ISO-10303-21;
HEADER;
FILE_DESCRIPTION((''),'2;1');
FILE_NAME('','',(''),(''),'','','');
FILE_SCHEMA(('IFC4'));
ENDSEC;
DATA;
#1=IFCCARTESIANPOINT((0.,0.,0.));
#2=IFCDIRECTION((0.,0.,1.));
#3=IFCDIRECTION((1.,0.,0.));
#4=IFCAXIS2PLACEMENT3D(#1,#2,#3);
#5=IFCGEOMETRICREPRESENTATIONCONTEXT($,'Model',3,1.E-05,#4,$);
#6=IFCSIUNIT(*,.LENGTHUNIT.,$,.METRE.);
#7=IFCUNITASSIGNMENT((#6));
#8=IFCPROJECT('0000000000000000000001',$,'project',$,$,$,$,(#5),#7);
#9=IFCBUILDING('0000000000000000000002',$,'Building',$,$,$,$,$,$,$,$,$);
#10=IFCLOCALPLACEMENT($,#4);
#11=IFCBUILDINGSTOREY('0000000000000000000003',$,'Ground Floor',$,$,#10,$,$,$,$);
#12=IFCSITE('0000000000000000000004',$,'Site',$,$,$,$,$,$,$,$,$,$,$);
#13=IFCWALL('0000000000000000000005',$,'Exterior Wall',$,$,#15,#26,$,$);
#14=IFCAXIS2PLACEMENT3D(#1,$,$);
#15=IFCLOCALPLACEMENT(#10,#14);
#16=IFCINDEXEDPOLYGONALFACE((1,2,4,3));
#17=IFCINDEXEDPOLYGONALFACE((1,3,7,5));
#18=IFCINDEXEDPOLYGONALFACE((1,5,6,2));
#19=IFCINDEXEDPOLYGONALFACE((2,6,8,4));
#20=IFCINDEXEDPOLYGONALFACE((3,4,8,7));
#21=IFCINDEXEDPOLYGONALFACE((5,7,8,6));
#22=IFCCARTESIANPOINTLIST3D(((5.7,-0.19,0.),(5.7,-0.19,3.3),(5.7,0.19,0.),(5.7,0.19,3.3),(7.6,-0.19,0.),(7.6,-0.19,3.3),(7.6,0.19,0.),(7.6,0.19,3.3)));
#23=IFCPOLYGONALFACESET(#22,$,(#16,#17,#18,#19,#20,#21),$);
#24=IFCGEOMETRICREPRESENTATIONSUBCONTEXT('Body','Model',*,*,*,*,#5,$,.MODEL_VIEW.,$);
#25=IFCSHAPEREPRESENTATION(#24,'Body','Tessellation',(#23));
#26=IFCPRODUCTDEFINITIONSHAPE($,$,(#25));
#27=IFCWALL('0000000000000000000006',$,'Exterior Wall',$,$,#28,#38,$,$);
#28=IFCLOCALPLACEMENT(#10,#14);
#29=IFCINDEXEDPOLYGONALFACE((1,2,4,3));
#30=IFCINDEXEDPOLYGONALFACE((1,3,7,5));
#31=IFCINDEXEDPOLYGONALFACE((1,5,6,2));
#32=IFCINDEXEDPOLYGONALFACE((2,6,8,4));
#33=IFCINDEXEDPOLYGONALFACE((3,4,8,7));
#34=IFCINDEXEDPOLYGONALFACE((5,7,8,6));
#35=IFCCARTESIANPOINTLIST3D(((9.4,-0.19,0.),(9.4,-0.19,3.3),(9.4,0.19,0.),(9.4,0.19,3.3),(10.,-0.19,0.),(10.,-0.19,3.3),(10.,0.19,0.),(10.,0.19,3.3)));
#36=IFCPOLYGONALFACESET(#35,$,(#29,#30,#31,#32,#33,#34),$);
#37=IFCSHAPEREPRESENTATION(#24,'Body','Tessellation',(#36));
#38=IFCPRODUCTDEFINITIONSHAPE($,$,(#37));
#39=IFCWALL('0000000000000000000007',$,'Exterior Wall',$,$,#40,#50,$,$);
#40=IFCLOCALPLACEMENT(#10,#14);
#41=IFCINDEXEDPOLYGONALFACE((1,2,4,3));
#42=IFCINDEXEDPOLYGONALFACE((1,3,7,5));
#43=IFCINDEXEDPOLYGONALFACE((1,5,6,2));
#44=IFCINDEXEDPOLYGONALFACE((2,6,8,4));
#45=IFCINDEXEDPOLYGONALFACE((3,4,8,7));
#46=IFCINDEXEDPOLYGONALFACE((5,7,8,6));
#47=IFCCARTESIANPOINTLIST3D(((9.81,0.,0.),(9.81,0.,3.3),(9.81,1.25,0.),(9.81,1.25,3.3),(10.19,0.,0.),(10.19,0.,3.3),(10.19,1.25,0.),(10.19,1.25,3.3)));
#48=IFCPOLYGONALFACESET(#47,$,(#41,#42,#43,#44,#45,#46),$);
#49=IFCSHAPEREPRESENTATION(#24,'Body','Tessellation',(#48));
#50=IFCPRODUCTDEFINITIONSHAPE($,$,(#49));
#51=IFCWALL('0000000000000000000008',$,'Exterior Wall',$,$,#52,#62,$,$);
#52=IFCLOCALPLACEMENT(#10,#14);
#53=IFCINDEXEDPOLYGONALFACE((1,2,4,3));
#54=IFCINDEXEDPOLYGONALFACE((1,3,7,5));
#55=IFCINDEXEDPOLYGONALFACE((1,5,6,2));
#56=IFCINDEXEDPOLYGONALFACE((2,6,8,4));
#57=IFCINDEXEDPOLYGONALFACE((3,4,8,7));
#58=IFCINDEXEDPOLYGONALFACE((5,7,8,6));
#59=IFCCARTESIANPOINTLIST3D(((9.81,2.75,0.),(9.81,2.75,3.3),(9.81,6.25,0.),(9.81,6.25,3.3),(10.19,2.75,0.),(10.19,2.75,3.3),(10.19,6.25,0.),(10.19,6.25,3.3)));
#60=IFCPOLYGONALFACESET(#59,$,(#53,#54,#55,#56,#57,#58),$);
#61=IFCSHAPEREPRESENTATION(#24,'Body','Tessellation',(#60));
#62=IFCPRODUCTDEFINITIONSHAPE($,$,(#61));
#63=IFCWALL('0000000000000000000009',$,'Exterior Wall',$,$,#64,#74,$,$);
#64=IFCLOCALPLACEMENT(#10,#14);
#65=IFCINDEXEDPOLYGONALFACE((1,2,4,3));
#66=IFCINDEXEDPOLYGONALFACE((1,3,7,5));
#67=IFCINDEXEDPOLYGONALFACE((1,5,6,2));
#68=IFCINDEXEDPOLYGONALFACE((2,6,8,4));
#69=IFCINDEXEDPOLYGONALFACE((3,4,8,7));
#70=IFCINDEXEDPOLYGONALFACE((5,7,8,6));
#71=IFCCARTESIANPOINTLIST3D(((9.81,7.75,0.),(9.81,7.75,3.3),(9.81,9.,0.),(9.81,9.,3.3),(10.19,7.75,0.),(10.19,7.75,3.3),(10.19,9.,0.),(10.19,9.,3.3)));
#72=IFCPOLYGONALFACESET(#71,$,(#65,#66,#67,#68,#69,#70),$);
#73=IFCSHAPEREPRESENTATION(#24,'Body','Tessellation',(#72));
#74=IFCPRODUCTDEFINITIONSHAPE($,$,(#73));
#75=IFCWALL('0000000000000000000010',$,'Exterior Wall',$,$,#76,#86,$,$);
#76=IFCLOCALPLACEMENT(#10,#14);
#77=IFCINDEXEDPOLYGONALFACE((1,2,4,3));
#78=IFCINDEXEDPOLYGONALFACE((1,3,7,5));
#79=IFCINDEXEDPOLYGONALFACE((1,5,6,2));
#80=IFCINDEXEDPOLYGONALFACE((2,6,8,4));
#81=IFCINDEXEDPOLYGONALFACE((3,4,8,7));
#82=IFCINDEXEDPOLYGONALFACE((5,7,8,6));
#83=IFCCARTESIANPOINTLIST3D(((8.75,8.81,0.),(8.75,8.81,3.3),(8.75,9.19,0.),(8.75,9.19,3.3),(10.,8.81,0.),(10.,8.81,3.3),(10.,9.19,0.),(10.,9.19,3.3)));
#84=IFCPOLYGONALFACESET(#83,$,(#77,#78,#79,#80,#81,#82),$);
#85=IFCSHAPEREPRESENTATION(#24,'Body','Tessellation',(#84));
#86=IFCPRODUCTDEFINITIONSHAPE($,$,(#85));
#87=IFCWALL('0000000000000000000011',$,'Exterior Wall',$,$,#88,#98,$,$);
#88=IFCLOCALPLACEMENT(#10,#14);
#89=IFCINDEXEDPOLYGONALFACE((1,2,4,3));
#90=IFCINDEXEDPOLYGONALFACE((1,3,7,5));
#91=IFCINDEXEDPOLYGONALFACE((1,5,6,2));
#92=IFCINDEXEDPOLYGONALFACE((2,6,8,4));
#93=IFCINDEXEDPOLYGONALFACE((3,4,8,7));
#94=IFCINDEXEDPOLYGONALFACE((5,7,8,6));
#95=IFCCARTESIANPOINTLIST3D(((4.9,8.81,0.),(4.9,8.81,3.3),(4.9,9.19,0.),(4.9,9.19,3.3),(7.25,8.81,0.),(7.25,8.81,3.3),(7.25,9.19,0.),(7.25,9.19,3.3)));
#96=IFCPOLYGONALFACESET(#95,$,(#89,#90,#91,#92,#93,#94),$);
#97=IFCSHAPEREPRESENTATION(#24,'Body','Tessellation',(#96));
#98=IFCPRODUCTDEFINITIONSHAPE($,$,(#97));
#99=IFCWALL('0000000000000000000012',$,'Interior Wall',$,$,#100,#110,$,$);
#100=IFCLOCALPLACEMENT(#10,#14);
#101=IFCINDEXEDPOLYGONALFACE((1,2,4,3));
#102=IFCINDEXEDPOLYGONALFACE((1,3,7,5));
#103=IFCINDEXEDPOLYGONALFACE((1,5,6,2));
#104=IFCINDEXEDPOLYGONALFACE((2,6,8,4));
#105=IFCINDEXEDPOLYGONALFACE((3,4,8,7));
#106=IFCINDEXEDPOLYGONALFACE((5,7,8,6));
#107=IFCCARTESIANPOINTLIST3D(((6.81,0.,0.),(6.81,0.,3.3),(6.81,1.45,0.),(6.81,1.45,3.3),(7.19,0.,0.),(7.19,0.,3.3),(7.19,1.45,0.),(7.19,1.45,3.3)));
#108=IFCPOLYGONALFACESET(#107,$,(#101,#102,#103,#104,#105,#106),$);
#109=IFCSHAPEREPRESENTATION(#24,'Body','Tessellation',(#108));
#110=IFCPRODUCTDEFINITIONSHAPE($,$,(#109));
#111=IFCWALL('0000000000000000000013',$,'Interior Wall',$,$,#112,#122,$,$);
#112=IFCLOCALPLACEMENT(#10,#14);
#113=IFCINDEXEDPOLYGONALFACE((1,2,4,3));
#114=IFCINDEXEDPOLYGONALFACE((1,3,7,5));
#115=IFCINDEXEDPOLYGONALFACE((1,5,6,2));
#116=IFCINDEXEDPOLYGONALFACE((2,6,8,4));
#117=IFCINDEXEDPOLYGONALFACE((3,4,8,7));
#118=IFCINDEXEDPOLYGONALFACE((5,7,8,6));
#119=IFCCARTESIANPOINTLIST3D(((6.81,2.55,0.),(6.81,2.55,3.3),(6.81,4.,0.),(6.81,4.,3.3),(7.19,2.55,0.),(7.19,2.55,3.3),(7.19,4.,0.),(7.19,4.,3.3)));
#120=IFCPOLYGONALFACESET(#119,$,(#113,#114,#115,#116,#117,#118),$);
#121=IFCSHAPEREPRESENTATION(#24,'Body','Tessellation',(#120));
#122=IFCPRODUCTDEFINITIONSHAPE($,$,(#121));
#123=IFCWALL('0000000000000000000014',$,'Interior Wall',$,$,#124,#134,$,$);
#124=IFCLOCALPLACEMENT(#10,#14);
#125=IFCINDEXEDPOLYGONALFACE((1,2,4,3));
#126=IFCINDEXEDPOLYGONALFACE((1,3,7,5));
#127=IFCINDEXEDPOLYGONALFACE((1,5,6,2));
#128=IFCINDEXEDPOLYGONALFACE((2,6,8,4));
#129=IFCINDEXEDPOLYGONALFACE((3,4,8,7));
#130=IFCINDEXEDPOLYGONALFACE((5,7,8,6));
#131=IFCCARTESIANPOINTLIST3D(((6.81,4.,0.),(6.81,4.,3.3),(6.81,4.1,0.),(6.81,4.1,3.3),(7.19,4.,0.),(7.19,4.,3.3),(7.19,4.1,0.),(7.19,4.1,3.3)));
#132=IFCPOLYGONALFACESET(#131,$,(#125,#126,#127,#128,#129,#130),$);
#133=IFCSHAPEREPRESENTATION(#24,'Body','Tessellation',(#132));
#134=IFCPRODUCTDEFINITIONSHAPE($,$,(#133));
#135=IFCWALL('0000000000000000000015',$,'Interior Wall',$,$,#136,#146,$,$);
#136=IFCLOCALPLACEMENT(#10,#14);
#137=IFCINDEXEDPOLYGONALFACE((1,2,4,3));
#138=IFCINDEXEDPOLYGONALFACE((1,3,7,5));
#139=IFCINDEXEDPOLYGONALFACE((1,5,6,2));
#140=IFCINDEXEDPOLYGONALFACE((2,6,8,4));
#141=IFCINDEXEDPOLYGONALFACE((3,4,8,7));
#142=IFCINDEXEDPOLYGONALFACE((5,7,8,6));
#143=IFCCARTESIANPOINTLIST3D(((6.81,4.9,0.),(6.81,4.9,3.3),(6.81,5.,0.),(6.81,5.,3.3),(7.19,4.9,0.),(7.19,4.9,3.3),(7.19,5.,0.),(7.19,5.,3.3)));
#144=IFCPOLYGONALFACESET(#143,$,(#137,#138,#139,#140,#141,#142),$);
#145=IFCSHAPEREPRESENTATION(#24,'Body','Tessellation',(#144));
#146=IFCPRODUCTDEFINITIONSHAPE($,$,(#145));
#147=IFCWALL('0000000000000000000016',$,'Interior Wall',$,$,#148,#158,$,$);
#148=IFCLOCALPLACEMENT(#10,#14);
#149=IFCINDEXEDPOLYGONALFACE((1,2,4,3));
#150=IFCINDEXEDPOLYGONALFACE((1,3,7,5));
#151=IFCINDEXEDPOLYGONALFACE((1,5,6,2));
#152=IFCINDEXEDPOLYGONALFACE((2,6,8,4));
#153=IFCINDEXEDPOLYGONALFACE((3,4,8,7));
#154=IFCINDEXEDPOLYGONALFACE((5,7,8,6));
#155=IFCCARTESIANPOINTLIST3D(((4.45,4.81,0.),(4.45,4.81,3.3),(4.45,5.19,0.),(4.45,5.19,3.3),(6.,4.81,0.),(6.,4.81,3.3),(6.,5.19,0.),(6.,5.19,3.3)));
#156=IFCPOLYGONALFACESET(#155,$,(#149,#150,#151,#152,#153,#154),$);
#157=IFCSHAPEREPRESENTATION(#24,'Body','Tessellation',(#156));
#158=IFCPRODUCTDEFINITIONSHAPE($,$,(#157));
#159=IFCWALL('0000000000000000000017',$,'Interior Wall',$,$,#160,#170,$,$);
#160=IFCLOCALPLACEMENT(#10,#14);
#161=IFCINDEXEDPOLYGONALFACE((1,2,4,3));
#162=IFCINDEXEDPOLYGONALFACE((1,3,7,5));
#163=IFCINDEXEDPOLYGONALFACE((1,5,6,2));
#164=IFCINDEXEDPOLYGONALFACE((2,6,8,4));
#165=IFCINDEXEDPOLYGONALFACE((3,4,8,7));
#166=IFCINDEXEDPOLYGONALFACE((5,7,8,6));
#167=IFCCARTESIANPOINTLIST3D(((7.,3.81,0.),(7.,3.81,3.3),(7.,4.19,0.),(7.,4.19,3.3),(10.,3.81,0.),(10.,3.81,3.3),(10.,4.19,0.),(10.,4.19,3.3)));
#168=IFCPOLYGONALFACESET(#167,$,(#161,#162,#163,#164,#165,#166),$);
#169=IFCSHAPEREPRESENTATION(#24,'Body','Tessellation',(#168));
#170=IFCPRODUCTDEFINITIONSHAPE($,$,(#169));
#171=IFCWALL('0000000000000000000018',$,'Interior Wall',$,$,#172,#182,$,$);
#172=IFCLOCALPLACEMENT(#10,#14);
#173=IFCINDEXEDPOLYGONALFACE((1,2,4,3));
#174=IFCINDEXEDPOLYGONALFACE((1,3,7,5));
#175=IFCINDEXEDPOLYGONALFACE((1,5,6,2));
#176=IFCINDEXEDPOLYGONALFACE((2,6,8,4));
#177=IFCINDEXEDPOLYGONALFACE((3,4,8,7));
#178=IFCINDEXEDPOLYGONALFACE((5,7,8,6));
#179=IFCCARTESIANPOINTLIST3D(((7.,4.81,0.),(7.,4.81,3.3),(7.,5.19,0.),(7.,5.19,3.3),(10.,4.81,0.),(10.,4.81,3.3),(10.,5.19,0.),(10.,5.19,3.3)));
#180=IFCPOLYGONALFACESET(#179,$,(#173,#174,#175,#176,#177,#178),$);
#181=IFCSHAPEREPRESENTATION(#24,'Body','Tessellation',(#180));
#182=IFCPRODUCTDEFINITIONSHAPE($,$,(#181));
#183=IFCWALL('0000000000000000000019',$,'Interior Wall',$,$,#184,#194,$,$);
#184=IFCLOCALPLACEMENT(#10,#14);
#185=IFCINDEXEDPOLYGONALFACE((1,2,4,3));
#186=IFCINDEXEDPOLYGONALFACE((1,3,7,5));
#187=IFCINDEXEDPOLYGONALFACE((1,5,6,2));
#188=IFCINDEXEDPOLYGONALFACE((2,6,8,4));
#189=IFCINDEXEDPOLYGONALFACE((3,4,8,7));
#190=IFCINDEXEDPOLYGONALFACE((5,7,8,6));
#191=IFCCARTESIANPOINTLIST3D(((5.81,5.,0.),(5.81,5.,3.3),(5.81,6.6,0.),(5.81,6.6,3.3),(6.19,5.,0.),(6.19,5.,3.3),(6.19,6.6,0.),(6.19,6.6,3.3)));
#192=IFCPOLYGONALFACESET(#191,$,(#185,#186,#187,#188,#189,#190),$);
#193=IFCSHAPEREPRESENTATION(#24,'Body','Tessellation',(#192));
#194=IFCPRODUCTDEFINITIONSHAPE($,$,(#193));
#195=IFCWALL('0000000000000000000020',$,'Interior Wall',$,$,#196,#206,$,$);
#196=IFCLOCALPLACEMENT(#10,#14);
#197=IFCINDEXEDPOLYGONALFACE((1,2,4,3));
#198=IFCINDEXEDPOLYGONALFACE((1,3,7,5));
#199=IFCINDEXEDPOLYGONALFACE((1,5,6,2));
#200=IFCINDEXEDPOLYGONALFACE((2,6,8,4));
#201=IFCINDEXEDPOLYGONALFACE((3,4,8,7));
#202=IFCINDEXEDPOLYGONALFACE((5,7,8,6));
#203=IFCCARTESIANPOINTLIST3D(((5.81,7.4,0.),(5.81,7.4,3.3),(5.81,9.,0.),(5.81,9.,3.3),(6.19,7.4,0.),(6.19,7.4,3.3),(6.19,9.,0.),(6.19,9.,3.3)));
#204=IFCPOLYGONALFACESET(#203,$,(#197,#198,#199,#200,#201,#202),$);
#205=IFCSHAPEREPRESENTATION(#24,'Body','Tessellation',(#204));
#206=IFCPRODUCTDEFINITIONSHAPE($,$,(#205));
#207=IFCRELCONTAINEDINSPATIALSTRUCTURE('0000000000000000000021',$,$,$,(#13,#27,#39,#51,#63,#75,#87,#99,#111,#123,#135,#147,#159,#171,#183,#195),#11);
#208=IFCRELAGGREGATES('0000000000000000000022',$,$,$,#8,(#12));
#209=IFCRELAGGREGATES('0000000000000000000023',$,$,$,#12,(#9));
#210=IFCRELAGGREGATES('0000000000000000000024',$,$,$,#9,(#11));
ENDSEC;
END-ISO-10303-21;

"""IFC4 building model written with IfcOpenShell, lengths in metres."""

from ifc_helpers import new_model, si_unit, frame, origin_with_axes, place, context, subcontext, project, spatial, indexed_curve, outline, extrude, element, save


model = new_model("IFC4")

# Units and contexts
model_context = context("Model", 3, precision=1e-05, world=origin_with_axes())
body_context = subcontext(model_context, "Body", "Model", "MODEL_VIEW")
ifc_project = project(units=[si_unit("LENGTHUNIT", "METRE")], contexts=[model_context])

# Site, building, storey
site = spatial("IfcSite", under=ifc_project, Name="Site")
building = spatial("IfcBuilding", under=site, Name="Building")
storey_placement = place(None, origin_with_axes())
storey = spatial("IfcBuildingStorey", under=building, at=storey_placement, Name="Ground Floor")

# Walls
wall_1_placement = place(storey_placement, frame((5.7, 0.0, 0.0), z_axis=(0.0, 0.0, 1.0), x_axis=(1.0, 0.0, 0.0)))
element("IfcWall", 1, at=wall_1_placement, inside=storey, Name="Exterior Wall", context=body_context, shape_type="SweptSolid", body=[
    extrude(outline(indexed_curve([(0.0, 0.0), (0.0, 0.38), (1.9, 0.38), (1.9, 0.0), (0.0, 0.0)], self_intersect=False)), frame((0.0, -0.19, 0.0), z_axis=(0.0, 0.0, 1.0), x_axis=(1.0, 0.0, 0.0)), (0.0, 0.0, 1.0), 3.3),
])
wall_2_placement = place(storey_placement, frame((9.4, 0.0, 0.0), z_axis=(0.0, 0.0, 1.0), x_axis=(1.0, 0.0, 0.0)))
element("IfcWall", 2, at=wall_2_placement, inside=storey, Name="Exterior Wall", context=body_context, shape_type="SweptSolid", body=[
    extrude(outline(indexed_curve([(0.0, 0.0), (0.0, 0.38), (0.6, 0.38), (0.6, 0.0), (0.0, 0.0)], self_intersect=False)), frame((0.0, -0.19, 0.0), z_axis=(0.0, 0.0, 1.0), x_axis=(1.0, 0.0, 0.0)), (0.0, 0.0, 1.0), 3.3),
])
wall_3_placement = place(storey_placement, frame((10.0, 0.0, 0.0), z_axis=(0.0, 0.0, 1.0), x_axis=(0.0, 1.0, 0.0)))
element("IfcWall", 3, at=wall_3_placement, inside=storey, Name="Exterior Wall", context=body_context, shape_type="SweptSolid", body=[
    extrude(outline(indexed_curve([(0.0, 0.0), (0.0, 0.38), (1.25, 0.38), (1.25, 0.0), (0.0, 0.0)], self_intersect=False)), frame((0.0, -0.19, 0.0), z_axis=(0.0, 0.0, 1.0), x_axis=(1.0, 0.0, 0.0)), (0.0, 0.0, 1.0), 3.3),
])
wall_4_placement = place(storey_placement, frame((10.0, 2.75, 0.0), z_axis=(0.0, 0.0, 1.0), x_axis=(0.0, 1.0, 0.0)))
element("IfcWall", 4, at=wall_4_placement, inside=storey, Name="Exterior Wall", context=body_context, shape_type="SweptSolid", body=[
    extrude(outline(indexed_curve([(0.0, 0.0), (0.0, 0.38), (3.5, 0.38), (3.5, 0.0), (0.0, 0.0)], self_intersect=False)), frame((0.0, -0.19, 0.0), z_axis=(0.0, 0.0, 1.0), x_axis=(1.0, 0.0, 0.0)), (0.0, 0.0, 1.0), 3.3),
])
for number, where, z_axis, x_axis, name in (
    (5, (10.0, 7.75, 0.0), (0.0, 0.0, 1.0), (0.0, 1.0, 0.0), "Exterior Wall"),
    (6, (10.0, 9.0, 0.0), (0.0, 0.0, 1.0), (-1.0, 0.0, 0.0), "Exterior Wall"),
):
    element("IfcWall", number, at=place(storey_placement, frame(where, z_axis=z_axis, x_axis=x_axis)), inside=storey, Name=name, context=body_context, shape_type="SweptSolid", body=[
        extrude(outline(indexed_curve([(0.0, 0.0), (0.0, 0.38), (1.25, 0.38), (1.25, 0.0), (0.0, 0.0)], self_intersect=False)), frame((0.0, -0.19, 0.0), z_axis=(0.0, 0.0, 1.0), x_axis=(1.0, 0.0, 0.0)), (0.0, 0.0, 1.0), 3.3),
    ])
wall_5_placement = place(storey_placement, frame((7.25, 9.0, 0.0), z_axis=(0.0, 0.0, 1.0), x_axis=(-1.0, 0.0, 0.0)))
element("IfcWall", 7, at=wall_5_placement, inside=storey, Name="Exterior Wall", context=body_context, shape_type="SweptSolid", body=[
    extrude(outline(indexed_curve([(0.0, 0.0), (0.0, 0.38), (2.35, 0.38), (2.35, 0.0), (0.0, 0.0)], self_intersect=False)), frame((0.0, -0.19, 0.0), z_axis=(0.0, 0.0, 1.0), x_axis=(1.0, 0.0, 0.0)), (0.0, 0.0, 1.0), 3.3),
])
wall_6_placement = place(storey_placement, frame((7.0, 0.0, 0.0), z_axis=(0.0, 0.0, 1.0), x_axis=(0.0, 1.0, 0.0)))
element("IfcWall", 8, at=wall_6_placement, inside=storey, Name="Interior Wall", context=body_context, shape_type="SweptSolid", body=[
    extrude(outline(indexed_curve([(0.0, 0.0), (0.0, 0.38), (1.45, 0.38), (1.45, 0.0), (0.0, 0.0)], self_intersect=False)), frame((0.0, -0.19, 0.0), z_axis=(0.0, 0.0, 1.0), x_axis=(1.0, 0.0, 0.0)), (0.0, 0.0, 1.0), 3.3),
])
wall_7_placement = place(storey_placement, frame((7.0, 2.55, 0.0), z_axis=(0.0, 0.0, 1.0), x_axis=(0.0, 1.0, 0.0)))
element("IfcWall", 9, at=wall_7_placement, inside=storey, Name="Interior Wall", context=body_context, shape_type="SweptSolid", body=[
    extrude(outline(indexed_curve([(0.0, 0.0), (0.0, 0.38), (1.45, 0.38), (1.45, 0.0), (0.0, 0.0)], self_intersect=False)), frame((0.0, -0.19, 0.0), z_axis=(0.0, 0.0, 1.0), x_axis=(1.0, 0.0, 0.0)), (0.0, 0.0, 1.0), 3.3),
])
for number, where, z_axis, x_axis, name in (
    (10, (7.0, 4.0, 0.0), (0.0, 0.0, 1.0), (0.0, 1.0, 0.0), "Interior Wall"),
    (11, (7.0, 4.9, 0.0), (0.0, 0.0, 1.0), (0.0, 1.0, 0.0), "Interior Wall"),
):
    element("IfcWall", number, at=place(storey_placement, frame(where, z_axis=z_axis, x_axis=x_axis)), inside=storey, Name=name, context=body_context, shape_type="SweptSolid", body=[
        extrude(outline(indexed_curve([(0.0, 0.0), (0.0, 0.38), (0.1, 0.38), (0.1, 0.0), (0.0, 0.0)], self_intersect=False)), frame((0.0, -0.19, 0.0), z_axis=(0.0, 0.0, 1.0), x_axis=(1.0, 0.0, 0.0)), (0.0, 0.0, 1.0), 3.3),
    ])
wall_8_placement = place(storey_placement, frame((6.0, 5.0, 0.0), z_axis=(0.0, 0.0, 1.0), x_axis=(-1.0, 0.0, 0.0)))
element("IfcWall", 12, at=wall_8_placement, inside=storey, Name="Interior Wall", context=body_context, shape_type="SweptSolid", body=[
    extrude(outline(indexed_curve([(0.0, 0.0), (0.0, 0.38), (1.55, 0.38), (1.55, 0.0), (0.0, 0.0)], self_intersect=False)), frame((0.0, -0.19, 0.0), z_axis=(0.0, 0.0, 1.0), x_axis=(1.0, 0.0, 0.0)), (0.0, 0.0, 1.0), 3.3),
])
for number, where, z_axis, x_axis, name in (
    (13, (10.0, 4.0, 0.0), (0.0, 0.0, 1.0), (-1.0, 0.0, 0.0), "Interior Wall"),
    (14, (10.0, 5.0, 0.0), (0.0, 0.0, 1.0), (-1.0, 0.0, 0.0), "Interior Wall"),
):
    element("IfcWall", number, at=place(storey_placement, frame(where, z_axis=z_axis, x_axis=x_axis)), inside=storey, Name=name, context=body_context, shape_type="SweptSolid", body=[
        extrude(outline(indexed_curve([(0.0, 0.0), (0.0, 0.38), (3.0, 0.38), (3.0, 0.0), (0.0, 0.0)], self_intersect=False)), frame((0.0, -0.19, 0.0), z_axis=(0.0, 0.0, 1.0), x_axis=(1.0, 0.0, 0.0)), (0.0, 0.0, 1.0), 3.3),
    ])
for number, where, z_axis, x_axis, name in (
    (15, (6.0, 5.0, 0.0), (0.0, 0.0, 1.0), (0.0, 1.0, 0.0), "Interior Wall"),
    (16, (6.0, 7.4, 0.0), (0.0, 0.0, 1.0), (0.0, 1.0, 0.0), "Interior Wall"),
):
    element("IfcWall", number, at=place(storey_placement, frame(where, z_axis=z_axis, x_axis=x_axis)), inside=storey, Name=name, context=body_context, shape_type="SweptSolid", body=[
        extrude(outline(indexed_curve([(0.0, 0.0), (0.0, 0.38), (1.6, 0.38), (1.6, 0.0), (0.0, 0.0)], self_intersect=False)), frame((0.0, -0.19, 0.0), z_axis=(0.0, 0.0, 1.0), x_axis=(1.0, 0.0, 0.0)), (0.0, 0.0, 1.0), 3.3),
    ])

save(model, "model.ifc")
